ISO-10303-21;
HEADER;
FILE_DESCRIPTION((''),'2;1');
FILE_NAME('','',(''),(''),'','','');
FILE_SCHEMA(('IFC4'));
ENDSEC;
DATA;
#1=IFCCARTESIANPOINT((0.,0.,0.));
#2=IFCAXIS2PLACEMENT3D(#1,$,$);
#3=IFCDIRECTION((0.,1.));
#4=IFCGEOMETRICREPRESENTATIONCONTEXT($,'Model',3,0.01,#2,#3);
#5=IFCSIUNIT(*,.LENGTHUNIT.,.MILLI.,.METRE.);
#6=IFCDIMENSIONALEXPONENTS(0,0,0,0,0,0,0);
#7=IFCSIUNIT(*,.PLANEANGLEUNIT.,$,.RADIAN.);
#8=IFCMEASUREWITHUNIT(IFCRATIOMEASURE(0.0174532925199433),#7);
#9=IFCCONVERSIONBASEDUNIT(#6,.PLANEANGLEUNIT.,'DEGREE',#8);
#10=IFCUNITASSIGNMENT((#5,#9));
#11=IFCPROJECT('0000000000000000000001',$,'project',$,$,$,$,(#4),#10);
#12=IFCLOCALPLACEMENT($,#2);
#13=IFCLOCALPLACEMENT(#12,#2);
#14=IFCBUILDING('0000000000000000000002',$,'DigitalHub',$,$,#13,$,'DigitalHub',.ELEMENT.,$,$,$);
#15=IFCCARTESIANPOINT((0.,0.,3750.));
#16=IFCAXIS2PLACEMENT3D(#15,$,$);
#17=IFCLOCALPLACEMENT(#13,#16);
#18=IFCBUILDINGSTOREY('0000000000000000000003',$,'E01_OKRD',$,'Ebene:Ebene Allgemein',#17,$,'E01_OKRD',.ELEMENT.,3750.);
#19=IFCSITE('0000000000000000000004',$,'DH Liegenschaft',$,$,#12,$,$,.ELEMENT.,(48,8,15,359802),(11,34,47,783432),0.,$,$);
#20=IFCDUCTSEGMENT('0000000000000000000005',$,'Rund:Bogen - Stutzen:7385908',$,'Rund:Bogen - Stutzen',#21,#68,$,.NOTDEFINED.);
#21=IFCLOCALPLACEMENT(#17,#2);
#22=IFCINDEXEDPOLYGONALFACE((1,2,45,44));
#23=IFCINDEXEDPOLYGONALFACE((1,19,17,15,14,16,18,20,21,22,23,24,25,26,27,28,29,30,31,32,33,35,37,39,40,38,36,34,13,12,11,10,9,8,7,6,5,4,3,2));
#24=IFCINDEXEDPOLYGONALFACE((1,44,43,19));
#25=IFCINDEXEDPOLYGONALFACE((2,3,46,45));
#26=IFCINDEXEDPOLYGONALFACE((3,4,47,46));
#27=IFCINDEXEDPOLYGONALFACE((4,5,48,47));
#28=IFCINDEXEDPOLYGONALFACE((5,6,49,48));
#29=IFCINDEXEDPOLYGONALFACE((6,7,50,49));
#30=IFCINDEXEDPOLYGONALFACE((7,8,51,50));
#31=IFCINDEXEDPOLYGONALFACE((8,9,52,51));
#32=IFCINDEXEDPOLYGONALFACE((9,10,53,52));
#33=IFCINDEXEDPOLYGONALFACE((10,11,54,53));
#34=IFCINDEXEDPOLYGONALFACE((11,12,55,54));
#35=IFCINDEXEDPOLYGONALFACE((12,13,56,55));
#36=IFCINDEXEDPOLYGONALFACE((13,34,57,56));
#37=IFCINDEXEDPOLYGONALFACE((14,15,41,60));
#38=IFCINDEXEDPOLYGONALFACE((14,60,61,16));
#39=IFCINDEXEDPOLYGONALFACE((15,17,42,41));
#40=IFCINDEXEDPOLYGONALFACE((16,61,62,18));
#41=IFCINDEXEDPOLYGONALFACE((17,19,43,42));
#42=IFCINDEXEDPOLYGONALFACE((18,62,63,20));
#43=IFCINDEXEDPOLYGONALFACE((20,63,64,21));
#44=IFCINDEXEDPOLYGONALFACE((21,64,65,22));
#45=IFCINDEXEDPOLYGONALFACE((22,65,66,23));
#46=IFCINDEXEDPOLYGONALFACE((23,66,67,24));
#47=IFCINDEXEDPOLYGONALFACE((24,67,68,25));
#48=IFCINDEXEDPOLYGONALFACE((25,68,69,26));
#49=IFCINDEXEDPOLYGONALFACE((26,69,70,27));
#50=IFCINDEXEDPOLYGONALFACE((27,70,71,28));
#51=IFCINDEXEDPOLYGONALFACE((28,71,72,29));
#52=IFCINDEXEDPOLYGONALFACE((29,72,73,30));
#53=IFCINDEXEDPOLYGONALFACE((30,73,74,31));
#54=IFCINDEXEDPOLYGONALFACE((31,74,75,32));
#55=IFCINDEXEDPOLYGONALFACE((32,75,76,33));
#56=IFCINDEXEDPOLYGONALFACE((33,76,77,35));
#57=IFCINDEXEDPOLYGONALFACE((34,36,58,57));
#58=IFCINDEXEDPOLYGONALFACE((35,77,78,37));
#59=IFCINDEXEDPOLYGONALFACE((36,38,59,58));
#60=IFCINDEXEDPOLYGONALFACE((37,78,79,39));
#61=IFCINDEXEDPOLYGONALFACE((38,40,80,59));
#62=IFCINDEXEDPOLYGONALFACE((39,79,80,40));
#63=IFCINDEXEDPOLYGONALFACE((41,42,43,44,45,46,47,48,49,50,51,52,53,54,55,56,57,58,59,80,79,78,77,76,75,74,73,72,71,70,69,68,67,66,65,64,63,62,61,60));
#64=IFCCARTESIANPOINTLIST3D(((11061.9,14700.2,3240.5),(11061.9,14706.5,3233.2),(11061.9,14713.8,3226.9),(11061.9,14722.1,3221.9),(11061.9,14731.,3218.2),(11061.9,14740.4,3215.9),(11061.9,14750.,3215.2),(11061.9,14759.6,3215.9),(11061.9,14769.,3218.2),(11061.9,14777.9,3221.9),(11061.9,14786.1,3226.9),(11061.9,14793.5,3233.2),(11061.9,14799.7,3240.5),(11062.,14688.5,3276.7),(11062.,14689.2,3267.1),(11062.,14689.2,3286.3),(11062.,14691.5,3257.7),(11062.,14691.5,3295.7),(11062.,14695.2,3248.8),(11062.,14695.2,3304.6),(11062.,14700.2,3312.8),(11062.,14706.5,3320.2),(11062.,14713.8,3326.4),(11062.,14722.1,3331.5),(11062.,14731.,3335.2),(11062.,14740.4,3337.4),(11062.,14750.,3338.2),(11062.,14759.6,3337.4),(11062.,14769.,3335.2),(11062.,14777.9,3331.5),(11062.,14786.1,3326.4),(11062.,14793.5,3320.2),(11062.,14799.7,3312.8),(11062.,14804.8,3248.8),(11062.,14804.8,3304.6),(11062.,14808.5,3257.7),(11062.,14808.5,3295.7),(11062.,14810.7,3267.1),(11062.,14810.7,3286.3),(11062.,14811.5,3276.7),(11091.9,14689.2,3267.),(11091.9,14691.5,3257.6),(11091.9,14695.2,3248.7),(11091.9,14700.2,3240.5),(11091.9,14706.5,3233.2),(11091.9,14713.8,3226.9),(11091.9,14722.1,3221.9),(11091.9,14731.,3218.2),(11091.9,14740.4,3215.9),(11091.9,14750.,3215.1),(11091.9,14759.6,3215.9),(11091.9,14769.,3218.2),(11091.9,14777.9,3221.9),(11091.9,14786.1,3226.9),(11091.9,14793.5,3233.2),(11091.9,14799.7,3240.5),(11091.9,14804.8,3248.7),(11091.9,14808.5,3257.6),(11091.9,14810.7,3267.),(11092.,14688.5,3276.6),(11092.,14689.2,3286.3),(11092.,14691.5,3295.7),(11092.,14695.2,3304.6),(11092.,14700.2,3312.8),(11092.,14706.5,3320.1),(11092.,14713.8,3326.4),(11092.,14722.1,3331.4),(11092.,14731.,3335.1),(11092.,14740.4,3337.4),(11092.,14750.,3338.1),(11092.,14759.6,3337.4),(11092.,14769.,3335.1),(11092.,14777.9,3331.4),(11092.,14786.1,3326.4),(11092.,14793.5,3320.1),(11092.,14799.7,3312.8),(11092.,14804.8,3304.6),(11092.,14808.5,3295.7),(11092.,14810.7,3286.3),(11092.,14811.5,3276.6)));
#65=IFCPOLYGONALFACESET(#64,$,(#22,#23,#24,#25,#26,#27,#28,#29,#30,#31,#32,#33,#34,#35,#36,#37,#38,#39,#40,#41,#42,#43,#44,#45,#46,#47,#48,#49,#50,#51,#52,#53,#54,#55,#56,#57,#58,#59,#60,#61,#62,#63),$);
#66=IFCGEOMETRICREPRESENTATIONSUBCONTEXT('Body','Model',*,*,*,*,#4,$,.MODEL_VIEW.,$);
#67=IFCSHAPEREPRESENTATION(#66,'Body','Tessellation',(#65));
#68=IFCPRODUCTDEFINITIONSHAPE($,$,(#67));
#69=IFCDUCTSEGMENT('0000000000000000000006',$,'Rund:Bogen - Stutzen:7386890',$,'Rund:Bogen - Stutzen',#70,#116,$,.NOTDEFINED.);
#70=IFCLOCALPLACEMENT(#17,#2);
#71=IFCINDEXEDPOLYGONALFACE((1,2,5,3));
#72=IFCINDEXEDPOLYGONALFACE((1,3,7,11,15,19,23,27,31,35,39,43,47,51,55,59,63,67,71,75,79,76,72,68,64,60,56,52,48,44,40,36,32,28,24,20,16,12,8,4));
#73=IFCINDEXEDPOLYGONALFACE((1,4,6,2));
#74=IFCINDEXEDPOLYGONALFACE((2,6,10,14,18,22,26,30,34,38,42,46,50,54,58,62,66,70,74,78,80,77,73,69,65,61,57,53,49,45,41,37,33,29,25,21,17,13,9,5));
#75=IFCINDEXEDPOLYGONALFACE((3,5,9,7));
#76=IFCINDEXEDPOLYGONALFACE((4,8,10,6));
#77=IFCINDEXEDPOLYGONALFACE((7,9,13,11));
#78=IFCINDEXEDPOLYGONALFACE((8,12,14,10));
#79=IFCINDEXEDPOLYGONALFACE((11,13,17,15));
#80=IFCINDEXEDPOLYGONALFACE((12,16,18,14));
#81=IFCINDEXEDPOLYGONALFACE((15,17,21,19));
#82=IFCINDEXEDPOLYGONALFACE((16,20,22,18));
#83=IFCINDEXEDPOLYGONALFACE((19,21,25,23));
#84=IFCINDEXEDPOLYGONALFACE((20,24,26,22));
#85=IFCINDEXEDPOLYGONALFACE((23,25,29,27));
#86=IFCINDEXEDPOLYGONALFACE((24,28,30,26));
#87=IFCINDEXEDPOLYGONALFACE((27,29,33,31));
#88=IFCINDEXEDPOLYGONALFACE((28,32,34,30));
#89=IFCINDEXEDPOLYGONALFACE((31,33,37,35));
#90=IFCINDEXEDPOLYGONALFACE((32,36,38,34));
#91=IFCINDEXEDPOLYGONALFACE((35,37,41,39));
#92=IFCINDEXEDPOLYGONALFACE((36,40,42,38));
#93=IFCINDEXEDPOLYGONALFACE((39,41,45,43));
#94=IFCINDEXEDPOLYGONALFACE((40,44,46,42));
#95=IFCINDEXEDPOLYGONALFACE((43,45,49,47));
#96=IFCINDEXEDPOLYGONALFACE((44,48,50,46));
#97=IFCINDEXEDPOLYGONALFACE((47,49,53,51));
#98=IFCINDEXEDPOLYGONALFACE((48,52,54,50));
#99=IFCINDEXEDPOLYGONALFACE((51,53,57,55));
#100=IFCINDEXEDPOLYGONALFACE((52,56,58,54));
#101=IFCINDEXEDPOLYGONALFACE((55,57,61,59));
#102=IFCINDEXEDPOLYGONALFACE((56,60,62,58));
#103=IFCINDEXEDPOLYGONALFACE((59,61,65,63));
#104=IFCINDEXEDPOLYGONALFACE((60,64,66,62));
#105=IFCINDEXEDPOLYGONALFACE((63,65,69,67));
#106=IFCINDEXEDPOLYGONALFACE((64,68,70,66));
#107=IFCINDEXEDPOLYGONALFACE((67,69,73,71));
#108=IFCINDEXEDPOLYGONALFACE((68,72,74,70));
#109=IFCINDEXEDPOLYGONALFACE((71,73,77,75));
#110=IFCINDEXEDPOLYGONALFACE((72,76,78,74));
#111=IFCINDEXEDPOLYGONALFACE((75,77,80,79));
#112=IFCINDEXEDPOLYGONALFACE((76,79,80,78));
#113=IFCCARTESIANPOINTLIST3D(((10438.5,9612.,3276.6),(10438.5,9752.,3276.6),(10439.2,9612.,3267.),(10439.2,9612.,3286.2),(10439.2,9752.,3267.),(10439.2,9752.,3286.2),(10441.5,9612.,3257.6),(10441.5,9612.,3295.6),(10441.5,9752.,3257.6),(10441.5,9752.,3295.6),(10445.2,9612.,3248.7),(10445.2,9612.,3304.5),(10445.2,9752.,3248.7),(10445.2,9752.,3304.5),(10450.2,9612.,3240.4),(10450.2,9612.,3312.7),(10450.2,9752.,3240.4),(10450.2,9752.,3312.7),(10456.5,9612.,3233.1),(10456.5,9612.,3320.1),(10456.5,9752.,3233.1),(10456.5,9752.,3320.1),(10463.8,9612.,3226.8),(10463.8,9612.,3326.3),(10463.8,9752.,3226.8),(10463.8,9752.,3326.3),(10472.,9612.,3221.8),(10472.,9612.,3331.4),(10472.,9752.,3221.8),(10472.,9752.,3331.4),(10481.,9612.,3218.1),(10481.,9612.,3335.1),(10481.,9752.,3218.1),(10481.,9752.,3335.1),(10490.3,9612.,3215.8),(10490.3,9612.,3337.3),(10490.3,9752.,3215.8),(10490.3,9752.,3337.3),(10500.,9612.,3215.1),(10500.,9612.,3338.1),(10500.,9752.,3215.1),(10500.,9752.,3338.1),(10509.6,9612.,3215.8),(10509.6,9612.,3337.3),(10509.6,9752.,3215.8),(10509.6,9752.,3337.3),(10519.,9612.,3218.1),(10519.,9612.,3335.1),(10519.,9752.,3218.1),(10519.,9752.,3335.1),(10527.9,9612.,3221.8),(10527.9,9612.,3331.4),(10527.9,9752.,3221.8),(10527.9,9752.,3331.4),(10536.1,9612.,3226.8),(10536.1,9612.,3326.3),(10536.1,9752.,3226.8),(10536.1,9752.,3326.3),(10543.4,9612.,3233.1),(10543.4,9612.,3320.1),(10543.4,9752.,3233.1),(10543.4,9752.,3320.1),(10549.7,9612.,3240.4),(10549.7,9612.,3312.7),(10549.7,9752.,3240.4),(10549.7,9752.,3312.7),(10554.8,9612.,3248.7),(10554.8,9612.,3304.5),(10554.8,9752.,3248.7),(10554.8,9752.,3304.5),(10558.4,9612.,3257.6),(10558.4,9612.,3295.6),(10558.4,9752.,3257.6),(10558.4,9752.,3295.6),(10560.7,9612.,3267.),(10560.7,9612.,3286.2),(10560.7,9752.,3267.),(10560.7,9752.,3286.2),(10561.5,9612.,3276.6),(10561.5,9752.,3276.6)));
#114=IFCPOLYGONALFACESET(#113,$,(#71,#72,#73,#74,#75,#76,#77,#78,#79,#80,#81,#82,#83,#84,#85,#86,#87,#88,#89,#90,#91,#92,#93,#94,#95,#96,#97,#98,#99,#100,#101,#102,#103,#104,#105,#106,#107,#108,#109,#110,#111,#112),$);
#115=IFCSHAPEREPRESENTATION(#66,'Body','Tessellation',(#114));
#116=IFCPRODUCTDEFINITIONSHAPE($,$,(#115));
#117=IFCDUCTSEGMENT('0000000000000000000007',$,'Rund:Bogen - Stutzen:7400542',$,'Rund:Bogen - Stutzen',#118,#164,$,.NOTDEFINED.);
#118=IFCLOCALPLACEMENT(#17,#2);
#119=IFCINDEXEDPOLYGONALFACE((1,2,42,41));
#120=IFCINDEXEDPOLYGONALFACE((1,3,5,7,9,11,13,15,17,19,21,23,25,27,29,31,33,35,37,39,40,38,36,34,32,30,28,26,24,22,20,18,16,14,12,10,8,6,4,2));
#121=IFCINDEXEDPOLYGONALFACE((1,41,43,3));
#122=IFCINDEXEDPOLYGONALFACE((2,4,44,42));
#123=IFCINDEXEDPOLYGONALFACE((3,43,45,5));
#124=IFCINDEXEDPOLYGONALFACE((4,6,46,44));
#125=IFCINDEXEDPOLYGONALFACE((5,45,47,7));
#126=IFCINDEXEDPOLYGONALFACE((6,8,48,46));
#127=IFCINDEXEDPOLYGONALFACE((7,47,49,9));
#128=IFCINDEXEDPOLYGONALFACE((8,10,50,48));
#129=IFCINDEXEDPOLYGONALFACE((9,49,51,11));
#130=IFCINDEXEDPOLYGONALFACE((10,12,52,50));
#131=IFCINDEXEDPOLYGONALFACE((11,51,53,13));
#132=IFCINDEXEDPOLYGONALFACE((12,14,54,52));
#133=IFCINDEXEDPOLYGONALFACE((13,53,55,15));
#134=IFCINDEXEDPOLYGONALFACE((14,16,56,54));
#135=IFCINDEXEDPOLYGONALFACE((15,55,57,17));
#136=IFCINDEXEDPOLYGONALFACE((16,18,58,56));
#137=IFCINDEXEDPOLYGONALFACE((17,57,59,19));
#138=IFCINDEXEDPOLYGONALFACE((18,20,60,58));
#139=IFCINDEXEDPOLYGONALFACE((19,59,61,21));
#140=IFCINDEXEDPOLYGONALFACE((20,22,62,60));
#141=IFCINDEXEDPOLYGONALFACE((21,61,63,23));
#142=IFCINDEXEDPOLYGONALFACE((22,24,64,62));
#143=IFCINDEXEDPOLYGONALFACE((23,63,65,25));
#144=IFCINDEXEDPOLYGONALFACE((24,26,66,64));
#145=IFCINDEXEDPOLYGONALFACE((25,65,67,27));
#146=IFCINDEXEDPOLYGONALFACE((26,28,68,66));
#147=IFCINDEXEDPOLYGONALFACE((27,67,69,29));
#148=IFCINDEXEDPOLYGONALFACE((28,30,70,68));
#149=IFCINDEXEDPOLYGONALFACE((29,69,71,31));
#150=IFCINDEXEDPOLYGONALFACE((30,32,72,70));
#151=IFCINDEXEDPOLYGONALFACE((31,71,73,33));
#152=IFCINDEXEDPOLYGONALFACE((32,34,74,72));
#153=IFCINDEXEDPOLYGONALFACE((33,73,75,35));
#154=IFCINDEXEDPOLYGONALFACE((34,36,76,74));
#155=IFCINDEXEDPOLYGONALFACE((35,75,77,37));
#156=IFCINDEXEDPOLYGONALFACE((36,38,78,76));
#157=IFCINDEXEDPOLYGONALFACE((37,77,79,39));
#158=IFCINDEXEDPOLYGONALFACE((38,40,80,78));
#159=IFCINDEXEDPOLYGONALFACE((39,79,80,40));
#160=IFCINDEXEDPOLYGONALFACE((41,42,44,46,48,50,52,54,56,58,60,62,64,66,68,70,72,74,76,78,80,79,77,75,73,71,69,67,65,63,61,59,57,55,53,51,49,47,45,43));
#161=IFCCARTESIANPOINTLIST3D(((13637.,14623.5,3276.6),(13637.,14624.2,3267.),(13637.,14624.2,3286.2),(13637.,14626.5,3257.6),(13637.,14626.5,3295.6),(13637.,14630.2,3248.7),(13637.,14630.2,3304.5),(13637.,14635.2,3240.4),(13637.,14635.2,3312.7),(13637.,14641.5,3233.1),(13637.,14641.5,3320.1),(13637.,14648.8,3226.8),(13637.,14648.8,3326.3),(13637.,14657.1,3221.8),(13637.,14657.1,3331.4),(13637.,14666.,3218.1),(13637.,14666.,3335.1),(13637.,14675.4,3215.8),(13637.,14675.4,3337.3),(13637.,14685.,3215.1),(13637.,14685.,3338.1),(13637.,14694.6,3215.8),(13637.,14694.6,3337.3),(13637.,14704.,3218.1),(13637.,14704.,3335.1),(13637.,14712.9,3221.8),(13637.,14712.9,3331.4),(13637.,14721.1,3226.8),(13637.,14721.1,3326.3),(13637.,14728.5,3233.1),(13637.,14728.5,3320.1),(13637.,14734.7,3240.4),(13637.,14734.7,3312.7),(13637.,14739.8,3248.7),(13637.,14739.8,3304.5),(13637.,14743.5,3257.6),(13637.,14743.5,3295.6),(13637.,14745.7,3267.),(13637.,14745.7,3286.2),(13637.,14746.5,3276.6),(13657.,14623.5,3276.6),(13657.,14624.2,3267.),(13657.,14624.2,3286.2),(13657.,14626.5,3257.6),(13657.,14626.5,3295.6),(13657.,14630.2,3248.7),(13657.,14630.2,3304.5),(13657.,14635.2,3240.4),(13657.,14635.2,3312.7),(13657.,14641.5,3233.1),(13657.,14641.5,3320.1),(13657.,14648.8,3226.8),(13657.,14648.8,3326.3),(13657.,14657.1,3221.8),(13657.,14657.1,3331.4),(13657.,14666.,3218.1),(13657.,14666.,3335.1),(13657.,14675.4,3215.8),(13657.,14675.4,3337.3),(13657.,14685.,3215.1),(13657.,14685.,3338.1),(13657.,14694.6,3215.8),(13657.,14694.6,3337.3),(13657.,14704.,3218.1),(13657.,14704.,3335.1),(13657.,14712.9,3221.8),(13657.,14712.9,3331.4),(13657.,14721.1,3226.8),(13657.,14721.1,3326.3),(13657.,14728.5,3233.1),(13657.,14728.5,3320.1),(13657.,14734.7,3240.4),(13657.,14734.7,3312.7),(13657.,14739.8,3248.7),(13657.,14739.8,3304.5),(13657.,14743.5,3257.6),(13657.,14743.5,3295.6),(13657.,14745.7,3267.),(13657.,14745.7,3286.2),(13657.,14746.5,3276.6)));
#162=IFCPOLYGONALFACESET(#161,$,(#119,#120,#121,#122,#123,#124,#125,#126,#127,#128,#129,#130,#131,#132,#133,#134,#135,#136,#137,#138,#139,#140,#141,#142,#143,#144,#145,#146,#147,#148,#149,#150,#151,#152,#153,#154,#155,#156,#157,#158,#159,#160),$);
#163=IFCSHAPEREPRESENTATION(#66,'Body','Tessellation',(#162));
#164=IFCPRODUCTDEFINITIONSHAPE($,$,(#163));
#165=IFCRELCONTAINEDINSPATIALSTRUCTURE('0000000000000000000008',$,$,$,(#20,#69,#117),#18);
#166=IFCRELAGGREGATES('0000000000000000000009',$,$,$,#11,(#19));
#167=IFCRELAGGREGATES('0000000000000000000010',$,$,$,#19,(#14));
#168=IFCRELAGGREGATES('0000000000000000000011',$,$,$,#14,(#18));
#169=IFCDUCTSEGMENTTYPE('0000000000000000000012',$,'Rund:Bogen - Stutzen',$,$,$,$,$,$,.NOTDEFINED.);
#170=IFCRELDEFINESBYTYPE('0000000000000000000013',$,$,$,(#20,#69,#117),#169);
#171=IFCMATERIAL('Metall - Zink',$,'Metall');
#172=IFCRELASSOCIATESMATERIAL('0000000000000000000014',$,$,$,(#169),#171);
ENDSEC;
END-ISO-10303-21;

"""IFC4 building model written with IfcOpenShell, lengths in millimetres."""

from ifc_helpers import new_model, entity, si_unit, converted_unit, direction, frame, origin, place, context, subcontext, project, spatial, indexed_curve, outline, extrude, material, type_object, element, save


model = new_model("IFC4")

# Units and contexts
model_context = context("Model", 3, precision=0.01, world=origin(), true_north=direction((0.0, 1.0)))
body_context = subcontext(model_context, "Body", "Model", "MODEL_VIEW")
ifc_project = project(units=[si_unit("LENGTHUNIT", "METRE", prefix="MILLI"), converted_unit("PLANEANGLEUNIT", "DEGREE", entity("IfcRatioMeasure", 0.0174532925199433), si_unit("PLANEANGLEUNIT", "RADIAN"), dimensions=[0, 0, 0, 0, 0, 0, 0])], contexts=[model_context])

# Site, building, storey
site_placement = place(None, origin())
site = spatial("IfcSite", under=ifc_project, at=site_placement, Name="DH Liegenschaft", CompositionType="ELEMENT", RefLatitude=(48, 8, 15, 359802), RefLongitude=(11, 34, 47, 783432), RefElevation=0.0)
building_placement = place(site_placement, origin())
building = spatial("IfcBuilding", under=site, at=building_placement, Name="DigitalHub", LongName="DigitalHub", CompositionType="ELEMENT")
storey_placement = place(building_placement, frame((0.0, 0.0, 3750.0)))
storey = spatial("IfcBuildingStorey", under=building, at=storey_placement, Name="E01_OKRD", ObjectType="Ebene:Ebene Allgemein", LongName="E01_OKRD", CompositionType="ELEMENT", Elevation=3750.0)

# Shared definitions
ifc_material_1 = material(Name="Metall - Zink", Category="Metall")

# Duct segments
duct_segment_type_1 = type_object("IfcDuctSegmentType", Name="Rund:Bogen - Stutzen", PredefinedType="NOTDEFINED", material=ifc_material_1)
duct_segment_1_placement = place(storey_placement, frame((11061.9, 14686.9, 3213.6)))
element("IfcDuctSegment", 1, at=duct_segment_1_placement, inside=storey, type_object=duct_segment_type_1, Name="Rund:Bogen - Stutzen:7385908", ObjectType="Rund:Bogen - Stutzen", PredefinedType="NOTDEFINED", context=body_context, shape_type="SweptSolid", body=[
    extrude(outline(indexed_curve([(61.5, 0.0), (60.7, 9.6), (58.5, 19.0), (54.8, 27.9), (49.8, 36.1), (43.5, 43.5), (36.1, 49.8), (27.9, 54.8), (19.0, 58.5), (9.6, 60.7), (0.0, 61.5), (-9.6, 60.7), (-19.0, 58.5), (-27.9, 54.8), (-36.1, 49.8), (-43.5, 43.5), (-49.8, 36.1), (-54.8, 27.9), (-58.5, 19.0), (-60.7, 9.6), (-61.5, 0.0), (-60.7, -9.6), (-58.5, -19.0), (-54.8, -27.9), (-49.8, -36.1), (-43.5, -43.5), (-36.1, -49.8), (-27.9, -54.8), (-19.0, -58.5), (-9.6, -60.7), (0.0, -61.5), (9.6, -60.7), (19.0, -58.5), (27.9, -54.8), (36.1, -49.8), (43.5, -43.5), (49.8, -36.1), (54.8, -27.9), (58.5, -19.0), (60.7, -9.6), (61.5, 0.0)], self_intersect=False)), frame((30.0, 63.1, 63.1), z_axis=(-1.0, 0.0, 0.000859), x_axis=(0.0, 1.0, 0.0)), (0.0, 0.0, 1.0), 30.0),
])
duct_segment_2_placement = place(storey_placement, frame((10436.9, 9612.0, 3213.5)))
element("IfcDuctSegment", 2, at=duct_segment_2_placement, inside=storey, type_object=duct_segment_type_1, Name="Rund:Bogen - Stutzen:7386890", ObjectType="Rund:Bogen - Stutzen", PredefinedType="NOTDEFINED", context=body_context, shape_type="SweptSolid", body=[
    extrude(outline(indexed_curve([(61.5, 0.0), (60.7, 9.6), (58.5, 19.0), (54.8, 27.9), (49.8, 36.1), (43.5, 43.5), (36.1, 49.8), (27.9, 54.8), (19.0, 58.5), (9.6, 60.7), (0.0, 61.5), (-9.6, 60.7), (-19.0, 58.5), (-27.9, 54.8), (-36.1, 49.8), (-43.5, 43.5), (-49.8, 36.1), (-54.8, 27.9), (-58.5, 19.0), (-60.7, 9.6), (-61.5, 0.0), (-60.7, -9.6), (-58.5, -19.0), (-54.8, -27.9), (-49.8, -36.1), (-43.5, -43.5), (-36.1, -49.8), (-27.9, -54.8), (-19.0, -58.5), (-9.6, -60.7), (0.0, -61.5), (9.6, -60.7), (19.0, -58.5), (27.9, -54.8), (36.1, -49.8), (43.5, -43.5), (49.8, -36.1), (54.8, -27.9), (58.5, -19.0), (60.7, -9.6), (61.5, 0.0)], self_intersect=False)), frame((63.1, 0.0, 63.1), z_axis=(0.0, 1.0, 0.0), x_axis=(-1.0, 0.0, 0.0)), (0.0, 0.0, 1.0), 140.0),
])
duct_segment_3_placement = place(storey_placement, frame((13637.0, 14621.9, 3213.5)))
element("IfcDuctSegment", 3, at=duct_segment_3_placement, inside=storey, type_object=duct_segment_type_1, Name="Rund:Bogen - Stutzen:7400542", ObjectType="Rund:Bogen - Stutzen", PredefinedType="NOTDEFINED", context=body_context, shape_type="SweptSolid", body=[
    extrude(outline(indexed_curve([(61.5, 0.0), (60.7, 9.6), (58.5, 19.0), (54.8, 27.9), (49.8, 36.1), (43.5, 43.5), (36.1, 49.8), (27.9, 54.8), (19.0, 58.5), (9.6, 60.7), (0.0, 61.5), (-9.6, 60.7), (-19.0, 58.5), (-27.9, 54.8), (-36.1, 49.8), (-43.5, 43.5), (-49.8, 36.1), (-54.8, 27.9), (-58.5, 19.0), (-60.7, 9.6), (-61.5, 0.0), (-60.7, -9.6), (-58.5, -19.0), (-54.8, -27.9), (-49.8, -36.1), (-43.5, -43.5), (-36.1, -49.8), (-27.9, -54.8), (-19.0, -58.5), (-9.6, -60.7), (0.0, -61.5), (9.6, -60.7), (19.0, -58.5), (27.9, -54.8), (36.1, -49.8), (43.5, -43.5), (49.8, -36.1), (54.8, -27.9), (58.5, -19.0), (60.7, -9.6), (61.5, 0.0)], self_intersect=False)), frame((0.0, 63.1, 63.1), z_axis=(1.0, 0.0, 0.0), x_axis=(0.0, 1.0, 0.0)), (0.0, 0.0, 1.0), 20.0),
])

save(model, "model.ifc")
